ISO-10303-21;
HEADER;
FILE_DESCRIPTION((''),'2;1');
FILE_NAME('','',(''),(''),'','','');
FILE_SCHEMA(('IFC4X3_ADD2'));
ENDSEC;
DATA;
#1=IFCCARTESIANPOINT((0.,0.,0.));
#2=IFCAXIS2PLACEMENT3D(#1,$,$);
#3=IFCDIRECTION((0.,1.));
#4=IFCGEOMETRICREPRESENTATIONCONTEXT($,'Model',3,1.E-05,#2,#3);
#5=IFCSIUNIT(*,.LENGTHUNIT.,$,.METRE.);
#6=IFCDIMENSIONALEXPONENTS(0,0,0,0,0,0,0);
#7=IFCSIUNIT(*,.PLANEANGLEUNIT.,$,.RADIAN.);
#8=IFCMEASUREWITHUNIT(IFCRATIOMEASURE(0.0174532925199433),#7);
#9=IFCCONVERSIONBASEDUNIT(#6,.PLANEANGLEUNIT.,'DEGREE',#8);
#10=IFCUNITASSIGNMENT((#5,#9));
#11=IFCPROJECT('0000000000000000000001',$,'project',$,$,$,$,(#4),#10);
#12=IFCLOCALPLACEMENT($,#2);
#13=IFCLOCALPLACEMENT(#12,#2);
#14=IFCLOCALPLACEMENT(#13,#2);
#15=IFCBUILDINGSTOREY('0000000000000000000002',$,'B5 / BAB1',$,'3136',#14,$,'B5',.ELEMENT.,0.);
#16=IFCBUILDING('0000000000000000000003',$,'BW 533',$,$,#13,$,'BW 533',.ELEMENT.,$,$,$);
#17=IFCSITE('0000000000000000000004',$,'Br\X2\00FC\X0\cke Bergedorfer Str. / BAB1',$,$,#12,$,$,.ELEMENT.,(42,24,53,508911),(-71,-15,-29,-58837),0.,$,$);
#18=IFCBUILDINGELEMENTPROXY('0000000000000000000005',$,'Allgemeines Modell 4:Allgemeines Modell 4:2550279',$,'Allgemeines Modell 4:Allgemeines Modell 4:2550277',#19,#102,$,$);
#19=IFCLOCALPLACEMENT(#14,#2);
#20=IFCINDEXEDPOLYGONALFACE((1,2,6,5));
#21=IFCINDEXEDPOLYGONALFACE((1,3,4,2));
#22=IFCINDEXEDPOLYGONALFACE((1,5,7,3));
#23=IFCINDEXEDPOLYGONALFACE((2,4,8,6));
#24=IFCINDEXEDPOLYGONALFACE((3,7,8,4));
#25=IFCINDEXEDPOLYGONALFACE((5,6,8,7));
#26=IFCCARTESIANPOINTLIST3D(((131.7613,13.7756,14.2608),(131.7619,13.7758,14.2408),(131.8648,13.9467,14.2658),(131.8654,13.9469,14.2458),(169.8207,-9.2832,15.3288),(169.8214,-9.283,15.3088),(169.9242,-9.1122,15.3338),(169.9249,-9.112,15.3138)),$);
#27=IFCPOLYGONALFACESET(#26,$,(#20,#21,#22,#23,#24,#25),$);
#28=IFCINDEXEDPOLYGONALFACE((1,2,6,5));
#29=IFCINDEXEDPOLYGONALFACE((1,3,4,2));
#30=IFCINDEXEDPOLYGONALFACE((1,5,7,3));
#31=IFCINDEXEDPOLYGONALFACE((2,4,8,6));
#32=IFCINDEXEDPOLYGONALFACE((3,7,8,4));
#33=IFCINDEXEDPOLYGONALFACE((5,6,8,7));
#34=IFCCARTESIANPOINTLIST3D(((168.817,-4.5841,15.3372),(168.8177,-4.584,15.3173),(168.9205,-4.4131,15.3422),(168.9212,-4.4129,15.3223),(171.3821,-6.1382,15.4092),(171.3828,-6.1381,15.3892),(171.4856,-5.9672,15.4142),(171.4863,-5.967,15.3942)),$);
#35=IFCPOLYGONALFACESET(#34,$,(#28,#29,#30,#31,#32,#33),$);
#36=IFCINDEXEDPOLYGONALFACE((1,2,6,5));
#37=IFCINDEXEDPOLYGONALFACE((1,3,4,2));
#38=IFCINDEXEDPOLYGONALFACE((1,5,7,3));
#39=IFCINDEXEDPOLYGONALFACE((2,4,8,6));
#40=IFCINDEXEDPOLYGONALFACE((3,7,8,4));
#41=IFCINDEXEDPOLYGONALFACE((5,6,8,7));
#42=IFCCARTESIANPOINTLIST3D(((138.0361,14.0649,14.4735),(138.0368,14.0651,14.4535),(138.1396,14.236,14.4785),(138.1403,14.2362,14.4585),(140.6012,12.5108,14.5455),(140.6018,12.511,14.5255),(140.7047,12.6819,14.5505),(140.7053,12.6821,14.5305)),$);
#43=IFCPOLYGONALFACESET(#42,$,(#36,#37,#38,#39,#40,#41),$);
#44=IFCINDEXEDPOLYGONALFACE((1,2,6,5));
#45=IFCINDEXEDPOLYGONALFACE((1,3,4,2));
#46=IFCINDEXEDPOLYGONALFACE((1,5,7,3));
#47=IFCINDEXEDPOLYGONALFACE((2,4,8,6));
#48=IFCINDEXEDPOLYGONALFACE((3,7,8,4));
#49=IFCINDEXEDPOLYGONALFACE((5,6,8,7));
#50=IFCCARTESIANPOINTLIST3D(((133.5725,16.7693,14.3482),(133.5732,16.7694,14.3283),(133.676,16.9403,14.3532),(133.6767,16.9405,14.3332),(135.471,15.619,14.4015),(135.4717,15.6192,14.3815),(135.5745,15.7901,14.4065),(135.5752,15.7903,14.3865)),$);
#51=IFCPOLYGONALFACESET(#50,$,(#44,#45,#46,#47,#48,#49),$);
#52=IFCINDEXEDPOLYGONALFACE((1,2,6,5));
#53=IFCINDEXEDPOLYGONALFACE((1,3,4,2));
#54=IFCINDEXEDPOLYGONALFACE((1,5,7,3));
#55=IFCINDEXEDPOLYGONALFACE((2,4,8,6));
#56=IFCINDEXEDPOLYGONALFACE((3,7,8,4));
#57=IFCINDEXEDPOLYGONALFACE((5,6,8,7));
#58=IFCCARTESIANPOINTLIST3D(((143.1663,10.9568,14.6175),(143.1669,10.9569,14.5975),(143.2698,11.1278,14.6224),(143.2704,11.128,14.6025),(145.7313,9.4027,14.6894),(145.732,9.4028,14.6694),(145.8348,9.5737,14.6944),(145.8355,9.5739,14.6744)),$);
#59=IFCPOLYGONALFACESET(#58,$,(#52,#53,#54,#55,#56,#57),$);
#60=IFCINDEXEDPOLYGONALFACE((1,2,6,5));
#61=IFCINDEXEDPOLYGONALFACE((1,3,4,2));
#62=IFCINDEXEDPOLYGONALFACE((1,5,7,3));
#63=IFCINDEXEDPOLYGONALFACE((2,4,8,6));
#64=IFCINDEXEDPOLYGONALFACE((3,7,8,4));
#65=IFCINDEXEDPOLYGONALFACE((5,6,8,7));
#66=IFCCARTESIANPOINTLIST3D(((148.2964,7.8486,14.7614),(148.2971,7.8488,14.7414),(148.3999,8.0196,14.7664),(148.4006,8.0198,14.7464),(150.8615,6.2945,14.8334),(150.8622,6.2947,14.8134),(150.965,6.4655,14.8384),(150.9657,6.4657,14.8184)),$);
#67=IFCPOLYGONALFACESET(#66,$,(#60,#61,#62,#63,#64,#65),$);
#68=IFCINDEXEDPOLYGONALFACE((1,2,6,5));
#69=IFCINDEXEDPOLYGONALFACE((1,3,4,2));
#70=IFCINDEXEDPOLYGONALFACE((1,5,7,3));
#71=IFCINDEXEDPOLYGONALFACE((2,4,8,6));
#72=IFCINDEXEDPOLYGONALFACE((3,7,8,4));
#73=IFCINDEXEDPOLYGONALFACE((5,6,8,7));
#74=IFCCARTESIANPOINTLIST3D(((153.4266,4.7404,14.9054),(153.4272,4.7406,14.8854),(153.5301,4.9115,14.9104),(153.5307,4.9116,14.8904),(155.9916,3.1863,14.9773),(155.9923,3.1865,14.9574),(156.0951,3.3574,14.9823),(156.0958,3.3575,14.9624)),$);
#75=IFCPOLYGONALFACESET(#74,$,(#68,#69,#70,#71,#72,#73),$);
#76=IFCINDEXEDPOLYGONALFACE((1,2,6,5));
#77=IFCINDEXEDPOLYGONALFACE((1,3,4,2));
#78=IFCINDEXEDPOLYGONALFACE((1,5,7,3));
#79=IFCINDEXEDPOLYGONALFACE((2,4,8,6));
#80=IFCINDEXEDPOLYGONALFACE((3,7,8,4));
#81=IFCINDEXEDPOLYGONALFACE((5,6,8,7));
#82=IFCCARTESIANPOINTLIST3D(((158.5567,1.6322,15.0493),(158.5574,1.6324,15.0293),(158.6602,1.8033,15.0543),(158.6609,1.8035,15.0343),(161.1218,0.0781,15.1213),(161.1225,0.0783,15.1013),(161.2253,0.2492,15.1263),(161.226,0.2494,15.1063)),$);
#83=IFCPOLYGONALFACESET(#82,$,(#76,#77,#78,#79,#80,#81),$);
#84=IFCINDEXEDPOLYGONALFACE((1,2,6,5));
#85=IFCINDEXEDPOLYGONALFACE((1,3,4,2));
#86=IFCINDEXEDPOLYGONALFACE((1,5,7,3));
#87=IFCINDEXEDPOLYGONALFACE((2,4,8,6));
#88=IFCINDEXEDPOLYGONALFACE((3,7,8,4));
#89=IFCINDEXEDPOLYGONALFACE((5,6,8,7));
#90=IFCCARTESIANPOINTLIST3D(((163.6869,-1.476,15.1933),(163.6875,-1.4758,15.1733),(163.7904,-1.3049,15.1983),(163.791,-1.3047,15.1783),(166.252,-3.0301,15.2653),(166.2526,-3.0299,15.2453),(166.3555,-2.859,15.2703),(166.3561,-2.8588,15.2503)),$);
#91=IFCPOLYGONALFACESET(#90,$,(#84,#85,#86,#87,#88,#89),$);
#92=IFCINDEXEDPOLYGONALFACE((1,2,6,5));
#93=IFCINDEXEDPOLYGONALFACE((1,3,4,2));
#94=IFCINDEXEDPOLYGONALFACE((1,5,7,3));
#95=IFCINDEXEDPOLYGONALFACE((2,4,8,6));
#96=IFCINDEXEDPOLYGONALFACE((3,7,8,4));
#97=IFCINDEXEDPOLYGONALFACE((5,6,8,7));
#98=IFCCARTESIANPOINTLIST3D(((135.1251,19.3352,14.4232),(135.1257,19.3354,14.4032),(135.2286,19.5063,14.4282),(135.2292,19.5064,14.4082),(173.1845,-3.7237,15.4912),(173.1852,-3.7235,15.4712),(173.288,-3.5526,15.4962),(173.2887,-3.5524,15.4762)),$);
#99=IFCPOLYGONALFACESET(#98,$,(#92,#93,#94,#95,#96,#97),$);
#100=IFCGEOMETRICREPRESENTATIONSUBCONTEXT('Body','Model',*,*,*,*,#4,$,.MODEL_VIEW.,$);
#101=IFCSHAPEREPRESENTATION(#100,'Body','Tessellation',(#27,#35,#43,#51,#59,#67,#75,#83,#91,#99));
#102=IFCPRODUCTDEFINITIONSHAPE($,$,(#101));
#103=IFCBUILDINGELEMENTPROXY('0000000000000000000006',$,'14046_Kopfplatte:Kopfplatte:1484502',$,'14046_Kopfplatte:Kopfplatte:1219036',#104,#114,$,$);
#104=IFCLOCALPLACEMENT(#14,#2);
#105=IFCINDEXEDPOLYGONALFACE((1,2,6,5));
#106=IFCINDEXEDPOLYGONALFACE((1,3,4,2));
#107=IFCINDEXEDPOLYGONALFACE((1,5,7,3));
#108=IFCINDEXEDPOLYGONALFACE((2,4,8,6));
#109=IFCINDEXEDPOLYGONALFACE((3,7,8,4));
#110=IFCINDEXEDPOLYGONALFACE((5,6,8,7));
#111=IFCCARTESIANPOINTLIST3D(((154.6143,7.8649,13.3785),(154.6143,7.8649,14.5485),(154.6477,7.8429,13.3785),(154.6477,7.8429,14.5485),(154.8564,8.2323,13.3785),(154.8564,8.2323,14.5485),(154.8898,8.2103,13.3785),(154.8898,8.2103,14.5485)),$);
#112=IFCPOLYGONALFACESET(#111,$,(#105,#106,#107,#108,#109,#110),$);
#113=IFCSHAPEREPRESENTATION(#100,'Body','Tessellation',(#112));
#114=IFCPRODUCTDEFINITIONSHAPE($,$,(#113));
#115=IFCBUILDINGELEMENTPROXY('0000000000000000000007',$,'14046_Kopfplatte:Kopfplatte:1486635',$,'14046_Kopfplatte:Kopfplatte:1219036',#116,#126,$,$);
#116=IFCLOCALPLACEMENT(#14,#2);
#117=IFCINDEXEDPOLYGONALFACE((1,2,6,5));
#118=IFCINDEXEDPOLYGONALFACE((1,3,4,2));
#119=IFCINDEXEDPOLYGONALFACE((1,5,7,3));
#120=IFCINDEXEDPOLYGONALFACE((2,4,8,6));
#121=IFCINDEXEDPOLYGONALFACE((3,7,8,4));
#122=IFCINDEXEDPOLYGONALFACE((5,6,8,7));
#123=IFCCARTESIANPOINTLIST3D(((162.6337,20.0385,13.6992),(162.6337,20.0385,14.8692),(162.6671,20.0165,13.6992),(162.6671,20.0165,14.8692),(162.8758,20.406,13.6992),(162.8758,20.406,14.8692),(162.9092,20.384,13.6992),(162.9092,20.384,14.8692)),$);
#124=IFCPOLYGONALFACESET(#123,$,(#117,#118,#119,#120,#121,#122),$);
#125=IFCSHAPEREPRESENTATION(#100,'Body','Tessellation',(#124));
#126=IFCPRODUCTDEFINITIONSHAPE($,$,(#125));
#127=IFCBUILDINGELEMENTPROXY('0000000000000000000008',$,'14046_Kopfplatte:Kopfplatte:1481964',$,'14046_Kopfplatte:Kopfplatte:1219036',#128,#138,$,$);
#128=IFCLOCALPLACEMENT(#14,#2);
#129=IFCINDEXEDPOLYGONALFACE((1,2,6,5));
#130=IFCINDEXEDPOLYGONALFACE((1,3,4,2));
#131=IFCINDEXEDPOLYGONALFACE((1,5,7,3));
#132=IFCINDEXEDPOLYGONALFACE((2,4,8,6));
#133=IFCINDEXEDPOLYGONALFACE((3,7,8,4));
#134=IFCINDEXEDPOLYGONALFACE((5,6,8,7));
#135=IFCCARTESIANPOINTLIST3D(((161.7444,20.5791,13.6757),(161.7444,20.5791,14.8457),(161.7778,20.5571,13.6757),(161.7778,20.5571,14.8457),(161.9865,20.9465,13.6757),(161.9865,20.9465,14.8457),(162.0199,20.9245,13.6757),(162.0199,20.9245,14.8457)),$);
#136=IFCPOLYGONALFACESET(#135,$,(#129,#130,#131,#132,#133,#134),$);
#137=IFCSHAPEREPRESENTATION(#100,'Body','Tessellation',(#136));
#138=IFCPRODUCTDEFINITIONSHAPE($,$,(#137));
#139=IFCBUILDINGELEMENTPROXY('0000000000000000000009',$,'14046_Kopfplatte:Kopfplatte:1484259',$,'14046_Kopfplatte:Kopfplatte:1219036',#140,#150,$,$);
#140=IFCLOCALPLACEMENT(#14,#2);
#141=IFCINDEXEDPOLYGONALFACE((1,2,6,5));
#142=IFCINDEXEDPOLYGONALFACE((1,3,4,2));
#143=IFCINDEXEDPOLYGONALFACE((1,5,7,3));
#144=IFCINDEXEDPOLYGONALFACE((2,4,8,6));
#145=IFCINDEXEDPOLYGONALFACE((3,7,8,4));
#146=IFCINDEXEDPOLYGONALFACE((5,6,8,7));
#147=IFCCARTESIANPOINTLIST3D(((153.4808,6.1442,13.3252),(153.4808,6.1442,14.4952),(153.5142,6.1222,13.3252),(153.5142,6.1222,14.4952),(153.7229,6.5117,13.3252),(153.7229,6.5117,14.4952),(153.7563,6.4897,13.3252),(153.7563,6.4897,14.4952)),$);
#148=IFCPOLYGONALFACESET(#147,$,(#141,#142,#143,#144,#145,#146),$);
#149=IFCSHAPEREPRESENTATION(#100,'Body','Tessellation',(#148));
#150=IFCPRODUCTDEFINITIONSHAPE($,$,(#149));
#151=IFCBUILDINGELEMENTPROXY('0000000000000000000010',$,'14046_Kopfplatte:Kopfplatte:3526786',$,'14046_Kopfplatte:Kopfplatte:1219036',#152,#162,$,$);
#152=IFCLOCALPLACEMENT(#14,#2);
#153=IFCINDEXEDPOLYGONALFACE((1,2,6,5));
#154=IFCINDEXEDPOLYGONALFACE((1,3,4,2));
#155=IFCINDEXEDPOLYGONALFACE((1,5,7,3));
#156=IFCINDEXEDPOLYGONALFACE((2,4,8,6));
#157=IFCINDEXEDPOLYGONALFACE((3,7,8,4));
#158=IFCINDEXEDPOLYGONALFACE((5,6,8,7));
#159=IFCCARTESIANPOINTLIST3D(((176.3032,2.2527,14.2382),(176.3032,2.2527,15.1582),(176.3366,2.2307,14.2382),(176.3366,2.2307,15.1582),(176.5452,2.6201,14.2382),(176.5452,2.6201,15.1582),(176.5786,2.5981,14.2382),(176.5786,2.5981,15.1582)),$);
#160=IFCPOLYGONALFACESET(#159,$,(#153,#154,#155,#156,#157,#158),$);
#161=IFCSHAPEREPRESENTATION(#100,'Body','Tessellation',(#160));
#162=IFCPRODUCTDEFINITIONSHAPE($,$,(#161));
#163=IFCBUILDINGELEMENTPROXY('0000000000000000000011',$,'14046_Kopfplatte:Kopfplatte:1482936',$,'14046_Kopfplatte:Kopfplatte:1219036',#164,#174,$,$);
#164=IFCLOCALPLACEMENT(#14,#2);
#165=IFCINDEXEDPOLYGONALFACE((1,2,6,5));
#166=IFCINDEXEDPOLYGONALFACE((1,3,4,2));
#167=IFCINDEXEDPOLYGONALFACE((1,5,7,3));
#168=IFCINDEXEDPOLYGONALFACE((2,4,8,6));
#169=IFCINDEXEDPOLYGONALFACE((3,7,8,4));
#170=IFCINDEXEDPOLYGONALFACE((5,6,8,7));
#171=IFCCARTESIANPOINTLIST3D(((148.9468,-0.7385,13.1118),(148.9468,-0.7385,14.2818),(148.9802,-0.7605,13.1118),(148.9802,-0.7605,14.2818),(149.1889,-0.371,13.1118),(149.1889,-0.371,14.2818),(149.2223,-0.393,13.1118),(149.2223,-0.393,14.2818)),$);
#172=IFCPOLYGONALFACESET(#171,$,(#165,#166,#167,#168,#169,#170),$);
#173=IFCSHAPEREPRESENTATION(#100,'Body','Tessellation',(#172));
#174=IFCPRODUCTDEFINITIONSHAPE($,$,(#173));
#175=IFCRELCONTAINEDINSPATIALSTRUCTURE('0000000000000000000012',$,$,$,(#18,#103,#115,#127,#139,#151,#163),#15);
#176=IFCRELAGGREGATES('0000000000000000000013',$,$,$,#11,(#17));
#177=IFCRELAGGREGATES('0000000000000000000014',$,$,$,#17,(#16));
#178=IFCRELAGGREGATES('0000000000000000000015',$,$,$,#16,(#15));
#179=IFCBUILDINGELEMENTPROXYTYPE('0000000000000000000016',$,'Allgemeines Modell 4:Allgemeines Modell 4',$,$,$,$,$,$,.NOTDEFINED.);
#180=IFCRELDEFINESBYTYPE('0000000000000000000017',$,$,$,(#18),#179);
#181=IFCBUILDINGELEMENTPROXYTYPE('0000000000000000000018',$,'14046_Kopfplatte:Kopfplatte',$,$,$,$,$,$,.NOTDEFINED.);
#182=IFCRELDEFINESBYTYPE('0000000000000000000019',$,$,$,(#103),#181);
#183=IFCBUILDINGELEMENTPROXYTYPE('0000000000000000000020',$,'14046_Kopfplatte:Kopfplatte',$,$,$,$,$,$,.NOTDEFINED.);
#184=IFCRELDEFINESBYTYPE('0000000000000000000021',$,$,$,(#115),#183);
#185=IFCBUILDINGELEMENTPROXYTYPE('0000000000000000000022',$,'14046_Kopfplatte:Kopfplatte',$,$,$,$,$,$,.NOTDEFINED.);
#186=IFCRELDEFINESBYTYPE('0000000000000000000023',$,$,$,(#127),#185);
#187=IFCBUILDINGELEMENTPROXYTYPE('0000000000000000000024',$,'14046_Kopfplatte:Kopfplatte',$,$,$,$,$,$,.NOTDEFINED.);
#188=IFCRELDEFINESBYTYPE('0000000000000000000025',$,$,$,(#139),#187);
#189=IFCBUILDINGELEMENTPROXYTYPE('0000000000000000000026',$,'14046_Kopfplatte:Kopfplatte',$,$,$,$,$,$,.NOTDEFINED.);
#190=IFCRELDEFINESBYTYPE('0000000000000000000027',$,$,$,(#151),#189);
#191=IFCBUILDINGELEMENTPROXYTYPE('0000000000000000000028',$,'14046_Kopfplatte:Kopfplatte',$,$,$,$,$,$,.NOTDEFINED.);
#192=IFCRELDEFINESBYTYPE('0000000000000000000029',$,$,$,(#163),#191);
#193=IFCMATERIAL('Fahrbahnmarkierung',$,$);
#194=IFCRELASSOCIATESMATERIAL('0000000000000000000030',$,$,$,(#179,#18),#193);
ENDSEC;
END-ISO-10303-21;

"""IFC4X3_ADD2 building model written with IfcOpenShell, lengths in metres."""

from ifc_helpers import new_model, entity, si_unit, converted_unit, direction, frame, frame_2d, origin, origin_2d_with_axis, place, context, subcontext, project, spatial, rectangle, extrude, source, transform, mapped, material, type_object, type_shapes, element, save


model = new_model("IFC4X3_ADD2")

# Units and contexts
model_context = context("Model", 3, precision=1e-05, world=origin(), true_north=direction((0.0, 1.0)))
body_context = subcontext(model_context, "Body", "Model", "MODEL_VIEW")
ifc_project = project(units=[si_unit("LENGTHUNIT", "METRE"), converted_unit("PLANEANGLEUNIT", "DEGREE", entity("IfcRatioMeasure", 0.0174532925199433), si_unit("PLANEANGLEUNIT", "RADIAN"), dimensions=[0, 0, 0, 0, 0, 0, 0])], contexts=[model_context])

# Site, building, storey
site_placement = place(None, origin())
site = spatial("IfcSite", under=ifc_project, at=site_placement, Name="Brücke Bergedorfer Str. / BAB1", CompositionType="ELEMENT", RefLatitude=(42, 24, 53, 508911), RefLongitude=(-71, -15, -29, -58837), RefElevation=0.0)
building_placement = place(site_placement, origin())
building = spatial("IfcBuilding", under=site, at=building_placement, Name="BW 533", LongName="BW 533", CompositionType="ELEMENT")
storey_placement = place(building_placement, origin())
storey = spatial("IfcBuildingStorey", under=building, at=storey_placement, Name="B5 / BAB1", ObjectType="3136", LongName="B5", CompositionType="ELEMENT", Elevation=0.0)

# Building element proxies
ifc_material_1 = material(Name="Fahrbahnmarkierung")
building_element_proxy_type_1 = type_object("IfcBuildingElementProxyType", Name="Allgemeines Modell 4:Allgemeines Modell 4", PredefinedType="NOTDEFINED", material=ifc_material_1)
shared_shape_1 = source(origin(), body_context, "Body", "SweptSolid", [
    extrude(rectangle(XDim=0.02, YDim=0.2, at=frame_2d((0.0, 0.0), x_axis=(0.0, 1.0))), frame((131.8134, 13.8613, 14.2533), z_axis=(0.855026, -0.51803, 0.023993), x_axis=(0.517505, 0.855316, 0.024978)), (0.0, 0.0, 1.0), 44.5126),
    extrude(rectangle(XDim=0.02, YDim=0.2, at=frame_2d((0.0, 0.0), x_axis=(1.0, 0.0))), frame((168.8691, -4.4985, 15.3297), z_axis=(0.855026, -0.51803, 0.023993), x_axis=(-0.033461, -0.00894, 0.9994)), (0.0, 0.0, 1.0), 3.0),
    extrude(rectangle(XDim=0.02, YDim=0.2, at=frame_2d((0.0, 0.0), x_axis=(1.0, 0.0))), frame((138.0882, 14.1506, 14.466), z_axis=(0.855026, -0.51803, 0.023993), x_axis=(-0.033461, -0.00894, 0.9994)), (0.0, 0.0, 1.0), 3.0),
    extrude(rectangle(XDim=0.02, YDim=0.2, at=frame_2d((0.0, 0.0), x_axis=(0.0, 1.0))), frame((133.6246, 16.8549, 14.3407), z_axis=(0.855026, -0.51803, 0.023993), x_axis=(0.517505, 0.855316, 0.024978)), (0.0, 0.0, 1.0), 2.2204),
    extrude(rectangle(XDim=0.02, YDim=0.2, at=frame_2d((0.0, 0.0), x_axis=(1.0, 0.0))), frame((143.2183, 11.0424, 14.61), z_axis=(0.855026, -0.51803, 0.023993), x_axis=(-0.033461, -0.00894, 0.9994)), (0.0, 0.0, 1.0), 3.0),
    extrude(rectangle(XDim=0.02, YDim=0.2, at=frame_2d((0.0, 0.0), x_axis=(1.0, 0.0))), frame((148.3485, 7.9342, 14.7539), z_axis=(0.855026, -0.51803, 0.023993), x_axis=(-0.033461, -0.00894, 0.9994)), (0.0, 0.0, 1.0), 3.0),
    extrude(rectangle(XDim=0.02, YDim=0.2, at=frame_2d((0.0, 0.0), x_axis=(1.0, 0.0))), frame((153.4786, 4.826, 14.8979), z_axis=(0.855026, -0.51803, 0.023993), x_axis=(-0.033461, -0.00894, 0.9994)), (0.0, 0.0, 1.0), 3.0),
    extrude(rectangle(XDim=0.02, YDim=0.2, at=frame_2d((0.0, 0.0), x_axis=(1.0, 0.0))), frame((158.6088, 1.7178, 15.0418), z_axis=(0.855026, -0.51803, 0.023993), x_axis=(-0.033461, -0.00894, 0.9994)), (0.0, 0.0, 1.0), 3.0),
    extrude(rectangle(XDim=0.02, YDim=0.2, at=frame_2d((0.0, 0.0), x_axis=(1.0, 0.0))), frame((163.739, -1.3903, 15.1858), z_axis=(0.855026, -0.51803, 0.023993), x_axis=(-0.033461, -0.00894, 0.9994)), (0.0, 0.0, 1.0), 3.0),
    extrude(rectangle(XDim=0.02, YDim=0.2, at=frame_2d((0.0, 0.0), x_axis=(0.0, 1.0))), frame((135.1771, 19.4208, 14.4157), z_axis=(0.855026, -0.51803, 0.023993), x_axis=(0.517505, 0.855316, 0.024978)), (0.0, 0.0, 1.0), 44.5126),
])
type_shapes(building_element_proxy_type_1, [shared_shape_1])
proxy_1_placement = place(storey_placement, origin())
element("IfcBuildingElementProxy", 1, at=proxy_1_placement, inside=storey, type_object=building_element_proxy_type_1, material=ifc_material_1, Name="Allgemeines Modell 4:Allgemeines Modell 4:2550279", ObjectType="Allgemeines Modell 4:Allgemeines Modell 4:2550277", context=body_context, shape_type="MappedRepresentation", body=[
    mapped(shared_shape_1, transform((0.0, 0.0, 0.0), scale=1.0)),
])
building_element_proxy_type_2 = type_object("IfcBuildingElementProxyType", Name="14046_Kopfplatte:Kopfplatte", PredefinedType="NOTDEFINED")
shared_shape_2 = source(origin(), body_context, "Body", "SweptSolid", [
    extrude(rectangle(XDim=0.04, YDim=0.44, at=frame_2d((0.0, 0.0), x_axis=(1.0, 0.0))), frame((154.7521, 8.0376, 13.3785), z_axis=(0.0, 0.0, 1.0), x_axis=(-0.835088, 0.550116, 0.0)), (0.0, 0.0, 1.0), 1.17),
])
type_shapes(building_element_proxy_type_2, [shared_shape_2])
proxy_2_placement = place(storey_placement, origin())
element("IfcBuildingElementProxy", 2, at=proxy_2_placement, inside=storey, type_object=building_element_proxy_type_2, Name="14046_Kopfplatte:Kopfplatte:1484502", ObjectType="14046_Kopfplatte:Kopfplatte:1219036", context=body_context, shape_type="MappedRepresentation", body=[
    mapped(shared_shape_2, transform((0.0, 0.0, 0.0), scale=1.0)),
])
building_element_proxy_type_3 = type_object("IfcBuildingElementProxyType", Name="14046_Kopfplatte:Kopfplatte", PredefinedType="NOTDEFINED")
shared_shape_3 = source(origin(), body_context, "Body", "SweptSolid", [
    extrude(rectangle(XDim=0.04, YDim=0.44, at=frame_2d((0.0, 0.0), x_axis=(1.0, 0.0))), frame((162.7715, 20.2112, 13.6992), z_axis=(0.0, 0.0, 1.0), x_axis=(-0.835088, 0.550116, 0.0)), (0.0, 0.0, 1.0), 1.17),
])
type_shapes(building_element_proxy_type_3, [shared_shape_3])
proxy_3_placement = place(storey_placement, origin())
element("IfcBuildingElementProxy", 3, at=proxy_3_placement, inside=storey, type_object=building_element_proxy_type_3, Name="14046_Kopfplatte:Kopfplatte:1486635", ObjectType="14046_Kopfplatte:Kopfplatte:1219036", context=body_context, shape_type="MappedRepresentation", body=[
    mapped(shared_shape_3, transform((0.0, 0.0, 0.0), scale=1.0)),
])
building_element_proxy_type_4 = type_object("IfcBuildingElementProxyType", Name="14046_Kopfplatte:Kopfplatte", PredefinedType="NOTDEFINED")
shared_shape_4 = source(origin(), body_context, "Body", "SweptSolid", [
    extrude(rectangle(XDim=0.04, YDim=0.44, at=frame_2d((0.0, 0.0), x_axis=(1.0, 0.0))), frame((161.8822, 20.7518, 13.6757), z_axis=(0.0, 0.0, 1.0), x_axis=(0.835088, -0.550116, 0.0)), (0.0, 0.0, 1.0), 1.17),
])
type_shapes(building_element_proxy_type_4, [shared_shape_4])
proxy_4_placement = place(storey_placement, origin())
element("IfcBuildingElementProxy", 4, at=proxy_4_placement, inside=storey, type_object=building_element_proxy_type_4, Name="14046_Kopfplatte:Kopfplatte:1481964", ObjectType="14046_Kopfplatte:Kopfplatte:1219036", context=body_context, shape_type="MappedRepresentation", body=[
    mapped(shared_shape_4, transform((0.0, 0.0, 0.0), scale=1.0)),
])
building_element_proxy_type_5 = type_object("IfcBuildingElementProxyType", Name="14046_Kopfplatte:Kopfplatte", PredefinedType="NOTDEFINED")
shared_shape_5 = source(origin(), body_context, "Body", "SweptSolid", [
    extrude(rectangle(XDim=0.04, YDim=0.44, at=origin_2d_with_axis()), frame((153.6186, 6.3169, 13.3252), z_axis=(0.0, 0.0, 1.0), x_axis=(-0.835088, 0.550116, 0.0)), (0.0, 0.0, 1.0), 1.17),
])
type_shapes(building_element_proxy_type_5, [shared_shape_5])
proxy_5_placement = place(storey_placement, origin())
element("IfcBuildingElementProxy", 5, at=proxy_5_placement, inside=storey, type_object=building_element_proxy_type_5, Name="14046_Kopfplatte:Kopfplatte:1484259", ObjectType="14046_Kopfplatte:Kopfplatte:1219036", context=body_context, shape_type="MappedRepresentation", body=[
    mapped(shared_shape_5, transform((0.0, 0.0, 0.0), scale=1.0)),
])
building_element_proxy_type_6 = type_object("IfcBuildingElementProxyType", Name="14046_Kopfplatte:Kopfplatte", PredefinedType="NOTDEFINED")
shared_shape_6 = source(origin(), body_context, "Body", "SweptSolid", [
    extrude(rectangle(XDim=0.04, YDim=0.44, at=frame_2d((0.0, 0.0), x_axis=(1.0, 0.0))), frame((176.4409, 2.4254, 14.2382), z_axis=(0.0, 0.0, 1.0), x_axis=(0.835088, -0.550116, 0.0)), (0.0, 0.0, 1.0), 0.92),
])
type_shapes(building_element_proxy_type_6, [shared_shape_6])
proxy_6_placement = place(storey_placement, origin())
element("IfcBuildingElementProxy", 6, at=proxy_6_placement, inside=storey, type_object=building_element_proxy_type_6, Name="14046_Kopfplatte:Kopfplatte:3526786", ObjectType="14046_Kopfplatte:Kopfplatte:1219036", context=body_context, shape_type="MappedRepresentation", body=[
    mapped(shared_shape_6, transform((0.0, 0.0, 0.0), scale=1.0)),
])
building_element_proxy_type_7 = type_object("IfcBuildingElementProxyType", Name="14046_Kopfplatte:Kopfplatte", PredefinedType="NOTDEFINED")
shared_shape_7 = source(origin(), body_context, "Body", "SweptSolid", [
    extrude(rectangle(XDim=0.04, YDim=0.44, at=frame_2d((0.0, 0.0), x_axis=(1.0, 0.0))), frame((149.0846, -0.5658, 13.1118), z_axis=(0.0, 0.0, 1.0), x_axis=(-0.835088, 0.550116, 0.0)), (0.0, 0.0, 1.0), 1.17),
])
type_shapes(building_element_proxy_type_7, [shared_shape_7])
proxy_7_placement = place(storey_placement, origin())
element("IfcBuildingElementProxy", 7, at=proxy_7_placement, inside=storey, type_object=building_element_proxy_type_7, Name="14046_Kopfplatte:Kopfplatte:1482936", ObjectType="14046_Kopfplatte:Kopfplatte:1219036", context=body_context, shape_type="MappedRepresentation", body=[
    mapped(shared_shape_7, transform((0.0, 0.0, 0.0), scale=1.0)),
])

save(model, "model.ifc")
